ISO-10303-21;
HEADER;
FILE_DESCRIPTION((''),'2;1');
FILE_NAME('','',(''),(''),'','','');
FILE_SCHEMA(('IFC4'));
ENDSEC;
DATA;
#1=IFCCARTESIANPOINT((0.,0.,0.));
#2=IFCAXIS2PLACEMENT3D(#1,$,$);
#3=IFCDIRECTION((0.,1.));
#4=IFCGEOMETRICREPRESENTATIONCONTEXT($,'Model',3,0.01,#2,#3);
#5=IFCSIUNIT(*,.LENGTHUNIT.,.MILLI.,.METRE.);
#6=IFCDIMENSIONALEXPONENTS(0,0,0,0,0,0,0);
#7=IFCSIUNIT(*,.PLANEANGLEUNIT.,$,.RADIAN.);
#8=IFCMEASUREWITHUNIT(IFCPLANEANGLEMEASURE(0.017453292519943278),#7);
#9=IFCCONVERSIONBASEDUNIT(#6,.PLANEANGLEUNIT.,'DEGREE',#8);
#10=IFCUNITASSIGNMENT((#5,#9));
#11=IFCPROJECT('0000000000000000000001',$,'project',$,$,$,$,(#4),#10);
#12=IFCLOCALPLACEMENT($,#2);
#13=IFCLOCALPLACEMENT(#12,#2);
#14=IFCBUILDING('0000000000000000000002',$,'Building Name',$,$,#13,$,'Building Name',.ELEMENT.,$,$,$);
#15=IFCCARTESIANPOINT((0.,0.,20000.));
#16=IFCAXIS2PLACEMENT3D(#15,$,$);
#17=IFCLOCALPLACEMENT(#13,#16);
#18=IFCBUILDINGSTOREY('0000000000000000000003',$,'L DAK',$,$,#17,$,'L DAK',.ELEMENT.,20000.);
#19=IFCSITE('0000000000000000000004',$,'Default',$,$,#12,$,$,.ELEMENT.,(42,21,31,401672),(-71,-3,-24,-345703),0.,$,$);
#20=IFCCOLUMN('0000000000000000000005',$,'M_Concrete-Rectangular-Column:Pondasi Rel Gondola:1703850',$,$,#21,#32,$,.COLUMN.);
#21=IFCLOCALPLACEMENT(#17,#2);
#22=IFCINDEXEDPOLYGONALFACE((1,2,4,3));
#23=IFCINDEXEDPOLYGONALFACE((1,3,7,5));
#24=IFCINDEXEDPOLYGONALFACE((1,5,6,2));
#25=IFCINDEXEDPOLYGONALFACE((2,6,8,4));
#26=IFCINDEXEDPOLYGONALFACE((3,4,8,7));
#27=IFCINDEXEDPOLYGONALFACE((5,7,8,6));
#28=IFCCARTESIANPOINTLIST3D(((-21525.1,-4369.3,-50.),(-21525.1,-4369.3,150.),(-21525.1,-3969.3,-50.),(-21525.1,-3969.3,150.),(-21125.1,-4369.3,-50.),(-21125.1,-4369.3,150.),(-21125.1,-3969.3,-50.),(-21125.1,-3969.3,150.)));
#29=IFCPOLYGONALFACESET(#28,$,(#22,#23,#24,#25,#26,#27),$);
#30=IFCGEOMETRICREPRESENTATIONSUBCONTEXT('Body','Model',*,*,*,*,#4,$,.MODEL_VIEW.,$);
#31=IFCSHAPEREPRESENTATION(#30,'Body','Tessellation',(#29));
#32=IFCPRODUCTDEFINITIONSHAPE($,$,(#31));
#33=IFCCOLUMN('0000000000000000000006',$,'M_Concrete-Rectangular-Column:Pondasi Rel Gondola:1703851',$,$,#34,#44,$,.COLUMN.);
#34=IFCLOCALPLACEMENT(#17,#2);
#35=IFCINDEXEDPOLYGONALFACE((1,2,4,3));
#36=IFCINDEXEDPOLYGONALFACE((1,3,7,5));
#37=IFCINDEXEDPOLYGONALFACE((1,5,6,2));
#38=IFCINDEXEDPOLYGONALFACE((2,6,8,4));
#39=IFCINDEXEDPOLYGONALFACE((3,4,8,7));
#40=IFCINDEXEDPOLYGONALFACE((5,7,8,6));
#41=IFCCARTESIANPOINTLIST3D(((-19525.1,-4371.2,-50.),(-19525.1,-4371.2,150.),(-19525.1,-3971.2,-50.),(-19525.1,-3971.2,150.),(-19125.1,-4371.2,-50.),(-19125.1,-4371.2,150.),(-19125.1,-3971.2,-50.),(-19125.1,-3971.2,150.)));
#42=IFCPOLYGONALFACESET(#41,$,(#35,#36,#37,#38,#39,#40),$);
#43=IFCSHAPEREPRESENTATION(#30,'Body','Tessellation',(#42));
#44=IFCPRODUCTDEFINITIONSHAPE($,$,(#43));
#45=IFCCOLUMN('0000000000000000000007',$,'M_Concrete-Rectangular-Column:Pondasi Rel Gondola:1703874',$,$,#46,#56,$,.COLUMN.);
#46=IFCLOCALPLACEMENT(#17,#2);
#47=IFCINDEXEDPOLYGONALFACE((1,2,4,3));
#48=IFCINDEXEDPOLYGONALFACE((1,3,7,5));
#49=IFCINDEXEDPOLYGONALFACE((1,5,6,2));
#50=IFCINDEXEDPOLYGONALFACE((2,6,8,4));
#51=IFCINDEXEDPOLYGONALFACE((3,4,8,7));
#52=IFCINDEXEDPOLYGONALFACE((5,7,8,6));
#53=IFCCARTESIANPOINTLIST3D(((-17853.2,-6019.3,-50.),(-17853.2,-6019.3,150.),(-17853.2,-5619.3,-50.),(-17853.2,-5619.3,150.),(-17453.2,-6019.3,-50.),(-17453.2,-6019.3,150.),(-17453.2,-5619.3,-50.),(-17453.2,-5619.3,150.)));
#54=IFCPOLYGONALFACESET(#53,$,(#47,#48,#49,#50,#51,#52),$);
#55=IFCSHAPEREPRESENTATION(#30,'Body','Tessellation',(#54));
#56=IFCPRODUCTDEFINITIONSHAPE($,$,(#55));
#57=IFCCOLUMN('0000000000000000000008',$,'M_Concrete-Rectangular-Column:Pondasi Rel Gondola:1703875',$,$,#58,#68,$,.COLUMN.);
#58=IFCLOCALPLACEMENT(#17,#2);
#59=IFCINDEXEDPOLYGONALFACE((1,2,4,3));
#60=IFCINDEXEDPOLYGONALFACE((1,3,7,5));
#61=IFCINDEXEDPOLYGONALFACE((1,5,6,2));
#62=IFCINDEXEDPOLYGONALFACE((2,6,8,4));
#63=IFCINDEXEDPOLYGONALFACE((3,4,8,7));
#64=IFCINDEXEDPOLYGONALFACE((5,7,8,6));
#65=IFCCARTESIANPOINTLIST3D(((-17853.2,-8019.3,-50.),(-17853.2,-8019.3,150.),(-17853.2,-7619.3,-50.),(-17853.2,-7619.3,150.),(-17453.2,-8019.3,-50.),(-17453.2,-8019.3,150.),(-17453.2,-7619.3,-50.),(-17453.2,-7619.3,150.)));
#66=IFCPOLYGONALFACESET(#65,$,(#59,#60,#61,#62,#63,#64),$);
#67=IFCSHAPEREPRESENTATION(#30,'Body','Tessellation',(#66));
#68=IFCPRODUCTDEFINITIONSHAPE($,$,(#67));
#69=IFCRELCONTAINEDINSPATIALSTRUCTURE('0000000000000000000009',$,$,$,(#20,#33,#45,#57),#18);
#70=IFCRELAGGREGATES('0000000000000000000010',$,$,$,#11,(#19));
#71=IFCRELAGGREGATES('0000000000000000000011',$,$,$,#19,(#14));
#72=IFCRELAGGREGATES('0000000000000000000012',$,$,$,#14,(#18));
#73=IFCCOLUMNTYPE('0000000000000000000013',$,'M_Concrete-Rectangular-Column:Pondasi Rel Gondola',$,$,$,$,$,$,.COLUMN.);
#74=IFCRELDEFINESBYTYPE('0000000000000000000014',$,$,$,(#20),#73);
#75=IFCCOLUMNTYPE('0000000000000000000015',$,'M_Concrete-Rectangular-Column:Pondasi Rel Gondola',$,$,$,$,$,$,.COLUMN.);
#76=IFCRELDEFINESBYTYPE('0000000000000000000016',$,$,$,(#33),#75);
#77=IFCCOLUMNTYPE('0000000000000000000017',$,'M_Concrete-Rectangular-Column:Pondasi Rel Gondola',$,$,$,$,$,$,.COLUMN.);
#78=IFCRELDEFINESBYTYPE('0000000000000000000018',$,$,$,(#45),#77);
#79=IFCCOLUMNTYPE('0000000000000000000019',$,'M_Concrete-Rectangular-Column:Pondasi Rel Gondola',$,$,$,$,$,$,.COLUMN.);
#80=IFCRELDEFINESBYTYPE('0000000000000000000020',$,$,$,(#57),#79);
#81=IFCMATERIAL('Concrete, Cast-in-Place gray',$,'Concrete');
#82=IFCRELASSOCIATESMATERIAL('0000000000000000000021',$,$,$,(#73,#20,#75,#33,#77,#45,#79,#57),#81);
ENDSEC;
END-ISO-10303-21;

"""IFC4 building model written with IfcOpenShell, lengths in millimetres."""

from ifc_helpers import new_model, entity, si_unit, converted_unit, direction, frame, origin, place, context, subcontext, project, spatial, indexed_curve, outline, extrude, source, transform, mapped, material, type_object, type_shapes, element, save


model = new_model("IFC4")

# Units and contexts
model_context = context("Model", 3, precision=0.01, world=origin(), true_north=direction((0.0, 1.0)))
body_context = subcontext(model_context, "Body", "Model", "MODEL_VIEW")
ifc_project = project(units=[si_unit("LENGTHUNIT", "METRE", prefix="MILLI"), converted_unit("PLANEANGLEUNIT", "DEGREE", entity("IfcPlaneAngleMeasure", 0.017453292519943278), si_unit("PLANEANGLEUNIT", "RADIAN"), dimensions=[0, 0, 0, 0, 0, 0, 0])], contexts=[model_context])

# Site, building, storey
site_placement = place(None, origin())
site = spatial("IfcSite", under=ifc_project, at=site_placement, Name="Default", CompositionType="ELEMENT", RefLatitude=(42, 21, 31, 401672), RefLongitude=(-71, -3, -24, -345703), RefElevation=0.0)
building_placement = place(site_placement, origin())
building = spatial("IfcBuilding", under=site, at=building_placement, Name="Building Name", LongName="Building Name", CompositionType="ELEMENT")
storey_placement = place(building_placement, frame((0.0, 0.0, 20000.0)))
storey = spatial("IfcBuildingStorey", under=building, at=storey_placement, Name="L DAK", LongName="L DAK", CompositionType="ELEMENT", Elevation=20000.0)

# Columns
ifc_material = material(Name="Concrete, Cast-in-Place gray", Category="Concrete")
column_type_1 = type_object("IfcColumnType", Name="M_Concrete-Rectangular-Column:Pondasi Rel Gondola", PredefinedType="COLUMN", material=ifc_material)
shared_shape_1 = source(origin(), body_context, "Body", "SweptSolid", [
    extrude(outline(indexed_curve([(-200.0, -200.0), (200.0, -200.0), (200.0, 200.0), (-200.0, 200.0), (-200.0, -200.0)], self_intersect=False)), frame((-21325.1, -4169.3, 19950.0), z_axis=(0.0, 0.0, 1.0), x_axis=(-1.0, 0.0, 0.0)), (0.0, 0.0, 1.0), 200.0),
])
type_shapes(column_type_1, [shared_shape_1])
column_1_placement = place(storey_placement, frame((0.0, 0.0, -20000.0)))
element("IfcColumn", 1, at=column_1_placement, inside=storey, type_object=column_type_1, material=ifc_material, Name="M_Concrete-Rectangular-Column:Pondasi Rel Gondola:1703850", PredefinedType="COLUMN", context=body_context, shape_type="MappedRepresentation", body=[
    mapped(shared_shape_1, transform((0.0, 0.0, 0.0), scale=1.0)),
])
column_type_2 = type_object("IfcColumnType", Name="M_Concrete-Rectangular-Column:Pondasi Rel Gondola", PredefinedType="COLUMN", material=ifc_material)
shared_shape_2 = source(origin(), body_context, "Body", "SweptSolid", [
    extrude(outline(indexed_curve([(-200.0, -200.0), (200.0, -200.0), (200.0, 200.0), (-200.0, 200.0), (-200.0, -200.0)], self_intersect=False)), frame((-19325.1, -4171.2, 19950.0), z_axis=(0.0, 0.0, 1.0), x_axis=(-1.0, 0.0, 0.0)), (0.0, 0.0, 1.0), 200.0),
])
type_shapes(column_type_2, [shared_shape_2])
column_2_placement = place(storey_placement, frame((0.0, 0.0, -20000.0)))
element("IfcColumn", 2, at=column_2_placement, inside=storey, type_object=column_type_2, material=ifc_material, Name="M_Concrete-Rectangular-Column:Pondasi Rel Gondola:1703851", PredefinedType="COLUMN", context=body_context, shape_type="MappedRepresentation", body=[
    mapped(shared_shape_2, transform((0.0, 0.0, 0.0), scale=1.0)),
])
column_type_3 = type_object("IfcColumnType", Name="M_Concrete-Rectangular-Column:Pondasi Rel Gondola", PredefinedType="COLUMN", material=ifc_material)
shared_shape_3 = source(origin(), body_context, "Body", "SweptSolid", [
    extrude(outline(indexed_curve([(-200.0, -200.0), (200.0, -200.0), (200.0, 200.0), (-200.0, 200.0), (-200.0, -200.0)], self_intersect=False)), frame((-17653.2, -5819.3, 19950.0), z_axis=(0.0, 0.0, 1.0), x_axis=(-1.0, 0.0, 0.0)), (0.0, 0.0, 1.0), 200.0),
])
type_shapes(column_type_3, [shared_shape_3])
column_3_placement = place(storey_placement, frame((0.0, 0.0, -20000.0)))
element("IfcColumn", 3, at=column_3_placement, inside=storey, type_object=column_type_3, material=ifc_material, Name="M_Concrete-Rectangular-Column:Pondasi Rel Gondola:1703874", PredefinedType="COLUMN", context=body_context, shape_type="MappedRepresentation", body=[
    mapped(shared_shape_3, transform((0.0, 0.0, 0.0), scale=1.0)),
])
column_type_4 = type_object("IfcColumnType", Name="M_Concrete-Rectangular-Column:Pondasi Rel Gondola", PredefinedType="COLUMN", material=ifc_material)
shared_shape_4 = source(origin(), body_context, "Body", "SweptSolid", [
    extrude(outline(indexed_curve([(-200.0, -200.0), (200.0, -200.0), (200.0, 200.0), (-200.0, 200.0), (-200.0, -200.0)], self_intersect=False)), frame((-17653.2, -7819.3, 19950.0), z_axis=(0.0, 0.0, 1.0), x_axis=(-1.0, 0.0, 0.0)), (0.0, 0.0, 1.0), 200.0),
])
type_shapes(column_type_4, [shared_shape_4])
column_4_placement = place(storey_placement, frame((0.0, 0.0, -20000.0)))
element("IfcColumn", 4, at=column_4_placement, inside=storey, type_object=column_type_4, material=ifc_material, Name="M_Concrete-Rectangular-Column:Pondasi Rel Gondola:1703875", PredefinedType="COLUMN", context=body_context, shape_type="MappedRepresentation", body=[
    mapped(shared_shape_4, transform((0.0, 0.0, 0.0), scale=1.0)),
])

save(model, "model.ifc")
